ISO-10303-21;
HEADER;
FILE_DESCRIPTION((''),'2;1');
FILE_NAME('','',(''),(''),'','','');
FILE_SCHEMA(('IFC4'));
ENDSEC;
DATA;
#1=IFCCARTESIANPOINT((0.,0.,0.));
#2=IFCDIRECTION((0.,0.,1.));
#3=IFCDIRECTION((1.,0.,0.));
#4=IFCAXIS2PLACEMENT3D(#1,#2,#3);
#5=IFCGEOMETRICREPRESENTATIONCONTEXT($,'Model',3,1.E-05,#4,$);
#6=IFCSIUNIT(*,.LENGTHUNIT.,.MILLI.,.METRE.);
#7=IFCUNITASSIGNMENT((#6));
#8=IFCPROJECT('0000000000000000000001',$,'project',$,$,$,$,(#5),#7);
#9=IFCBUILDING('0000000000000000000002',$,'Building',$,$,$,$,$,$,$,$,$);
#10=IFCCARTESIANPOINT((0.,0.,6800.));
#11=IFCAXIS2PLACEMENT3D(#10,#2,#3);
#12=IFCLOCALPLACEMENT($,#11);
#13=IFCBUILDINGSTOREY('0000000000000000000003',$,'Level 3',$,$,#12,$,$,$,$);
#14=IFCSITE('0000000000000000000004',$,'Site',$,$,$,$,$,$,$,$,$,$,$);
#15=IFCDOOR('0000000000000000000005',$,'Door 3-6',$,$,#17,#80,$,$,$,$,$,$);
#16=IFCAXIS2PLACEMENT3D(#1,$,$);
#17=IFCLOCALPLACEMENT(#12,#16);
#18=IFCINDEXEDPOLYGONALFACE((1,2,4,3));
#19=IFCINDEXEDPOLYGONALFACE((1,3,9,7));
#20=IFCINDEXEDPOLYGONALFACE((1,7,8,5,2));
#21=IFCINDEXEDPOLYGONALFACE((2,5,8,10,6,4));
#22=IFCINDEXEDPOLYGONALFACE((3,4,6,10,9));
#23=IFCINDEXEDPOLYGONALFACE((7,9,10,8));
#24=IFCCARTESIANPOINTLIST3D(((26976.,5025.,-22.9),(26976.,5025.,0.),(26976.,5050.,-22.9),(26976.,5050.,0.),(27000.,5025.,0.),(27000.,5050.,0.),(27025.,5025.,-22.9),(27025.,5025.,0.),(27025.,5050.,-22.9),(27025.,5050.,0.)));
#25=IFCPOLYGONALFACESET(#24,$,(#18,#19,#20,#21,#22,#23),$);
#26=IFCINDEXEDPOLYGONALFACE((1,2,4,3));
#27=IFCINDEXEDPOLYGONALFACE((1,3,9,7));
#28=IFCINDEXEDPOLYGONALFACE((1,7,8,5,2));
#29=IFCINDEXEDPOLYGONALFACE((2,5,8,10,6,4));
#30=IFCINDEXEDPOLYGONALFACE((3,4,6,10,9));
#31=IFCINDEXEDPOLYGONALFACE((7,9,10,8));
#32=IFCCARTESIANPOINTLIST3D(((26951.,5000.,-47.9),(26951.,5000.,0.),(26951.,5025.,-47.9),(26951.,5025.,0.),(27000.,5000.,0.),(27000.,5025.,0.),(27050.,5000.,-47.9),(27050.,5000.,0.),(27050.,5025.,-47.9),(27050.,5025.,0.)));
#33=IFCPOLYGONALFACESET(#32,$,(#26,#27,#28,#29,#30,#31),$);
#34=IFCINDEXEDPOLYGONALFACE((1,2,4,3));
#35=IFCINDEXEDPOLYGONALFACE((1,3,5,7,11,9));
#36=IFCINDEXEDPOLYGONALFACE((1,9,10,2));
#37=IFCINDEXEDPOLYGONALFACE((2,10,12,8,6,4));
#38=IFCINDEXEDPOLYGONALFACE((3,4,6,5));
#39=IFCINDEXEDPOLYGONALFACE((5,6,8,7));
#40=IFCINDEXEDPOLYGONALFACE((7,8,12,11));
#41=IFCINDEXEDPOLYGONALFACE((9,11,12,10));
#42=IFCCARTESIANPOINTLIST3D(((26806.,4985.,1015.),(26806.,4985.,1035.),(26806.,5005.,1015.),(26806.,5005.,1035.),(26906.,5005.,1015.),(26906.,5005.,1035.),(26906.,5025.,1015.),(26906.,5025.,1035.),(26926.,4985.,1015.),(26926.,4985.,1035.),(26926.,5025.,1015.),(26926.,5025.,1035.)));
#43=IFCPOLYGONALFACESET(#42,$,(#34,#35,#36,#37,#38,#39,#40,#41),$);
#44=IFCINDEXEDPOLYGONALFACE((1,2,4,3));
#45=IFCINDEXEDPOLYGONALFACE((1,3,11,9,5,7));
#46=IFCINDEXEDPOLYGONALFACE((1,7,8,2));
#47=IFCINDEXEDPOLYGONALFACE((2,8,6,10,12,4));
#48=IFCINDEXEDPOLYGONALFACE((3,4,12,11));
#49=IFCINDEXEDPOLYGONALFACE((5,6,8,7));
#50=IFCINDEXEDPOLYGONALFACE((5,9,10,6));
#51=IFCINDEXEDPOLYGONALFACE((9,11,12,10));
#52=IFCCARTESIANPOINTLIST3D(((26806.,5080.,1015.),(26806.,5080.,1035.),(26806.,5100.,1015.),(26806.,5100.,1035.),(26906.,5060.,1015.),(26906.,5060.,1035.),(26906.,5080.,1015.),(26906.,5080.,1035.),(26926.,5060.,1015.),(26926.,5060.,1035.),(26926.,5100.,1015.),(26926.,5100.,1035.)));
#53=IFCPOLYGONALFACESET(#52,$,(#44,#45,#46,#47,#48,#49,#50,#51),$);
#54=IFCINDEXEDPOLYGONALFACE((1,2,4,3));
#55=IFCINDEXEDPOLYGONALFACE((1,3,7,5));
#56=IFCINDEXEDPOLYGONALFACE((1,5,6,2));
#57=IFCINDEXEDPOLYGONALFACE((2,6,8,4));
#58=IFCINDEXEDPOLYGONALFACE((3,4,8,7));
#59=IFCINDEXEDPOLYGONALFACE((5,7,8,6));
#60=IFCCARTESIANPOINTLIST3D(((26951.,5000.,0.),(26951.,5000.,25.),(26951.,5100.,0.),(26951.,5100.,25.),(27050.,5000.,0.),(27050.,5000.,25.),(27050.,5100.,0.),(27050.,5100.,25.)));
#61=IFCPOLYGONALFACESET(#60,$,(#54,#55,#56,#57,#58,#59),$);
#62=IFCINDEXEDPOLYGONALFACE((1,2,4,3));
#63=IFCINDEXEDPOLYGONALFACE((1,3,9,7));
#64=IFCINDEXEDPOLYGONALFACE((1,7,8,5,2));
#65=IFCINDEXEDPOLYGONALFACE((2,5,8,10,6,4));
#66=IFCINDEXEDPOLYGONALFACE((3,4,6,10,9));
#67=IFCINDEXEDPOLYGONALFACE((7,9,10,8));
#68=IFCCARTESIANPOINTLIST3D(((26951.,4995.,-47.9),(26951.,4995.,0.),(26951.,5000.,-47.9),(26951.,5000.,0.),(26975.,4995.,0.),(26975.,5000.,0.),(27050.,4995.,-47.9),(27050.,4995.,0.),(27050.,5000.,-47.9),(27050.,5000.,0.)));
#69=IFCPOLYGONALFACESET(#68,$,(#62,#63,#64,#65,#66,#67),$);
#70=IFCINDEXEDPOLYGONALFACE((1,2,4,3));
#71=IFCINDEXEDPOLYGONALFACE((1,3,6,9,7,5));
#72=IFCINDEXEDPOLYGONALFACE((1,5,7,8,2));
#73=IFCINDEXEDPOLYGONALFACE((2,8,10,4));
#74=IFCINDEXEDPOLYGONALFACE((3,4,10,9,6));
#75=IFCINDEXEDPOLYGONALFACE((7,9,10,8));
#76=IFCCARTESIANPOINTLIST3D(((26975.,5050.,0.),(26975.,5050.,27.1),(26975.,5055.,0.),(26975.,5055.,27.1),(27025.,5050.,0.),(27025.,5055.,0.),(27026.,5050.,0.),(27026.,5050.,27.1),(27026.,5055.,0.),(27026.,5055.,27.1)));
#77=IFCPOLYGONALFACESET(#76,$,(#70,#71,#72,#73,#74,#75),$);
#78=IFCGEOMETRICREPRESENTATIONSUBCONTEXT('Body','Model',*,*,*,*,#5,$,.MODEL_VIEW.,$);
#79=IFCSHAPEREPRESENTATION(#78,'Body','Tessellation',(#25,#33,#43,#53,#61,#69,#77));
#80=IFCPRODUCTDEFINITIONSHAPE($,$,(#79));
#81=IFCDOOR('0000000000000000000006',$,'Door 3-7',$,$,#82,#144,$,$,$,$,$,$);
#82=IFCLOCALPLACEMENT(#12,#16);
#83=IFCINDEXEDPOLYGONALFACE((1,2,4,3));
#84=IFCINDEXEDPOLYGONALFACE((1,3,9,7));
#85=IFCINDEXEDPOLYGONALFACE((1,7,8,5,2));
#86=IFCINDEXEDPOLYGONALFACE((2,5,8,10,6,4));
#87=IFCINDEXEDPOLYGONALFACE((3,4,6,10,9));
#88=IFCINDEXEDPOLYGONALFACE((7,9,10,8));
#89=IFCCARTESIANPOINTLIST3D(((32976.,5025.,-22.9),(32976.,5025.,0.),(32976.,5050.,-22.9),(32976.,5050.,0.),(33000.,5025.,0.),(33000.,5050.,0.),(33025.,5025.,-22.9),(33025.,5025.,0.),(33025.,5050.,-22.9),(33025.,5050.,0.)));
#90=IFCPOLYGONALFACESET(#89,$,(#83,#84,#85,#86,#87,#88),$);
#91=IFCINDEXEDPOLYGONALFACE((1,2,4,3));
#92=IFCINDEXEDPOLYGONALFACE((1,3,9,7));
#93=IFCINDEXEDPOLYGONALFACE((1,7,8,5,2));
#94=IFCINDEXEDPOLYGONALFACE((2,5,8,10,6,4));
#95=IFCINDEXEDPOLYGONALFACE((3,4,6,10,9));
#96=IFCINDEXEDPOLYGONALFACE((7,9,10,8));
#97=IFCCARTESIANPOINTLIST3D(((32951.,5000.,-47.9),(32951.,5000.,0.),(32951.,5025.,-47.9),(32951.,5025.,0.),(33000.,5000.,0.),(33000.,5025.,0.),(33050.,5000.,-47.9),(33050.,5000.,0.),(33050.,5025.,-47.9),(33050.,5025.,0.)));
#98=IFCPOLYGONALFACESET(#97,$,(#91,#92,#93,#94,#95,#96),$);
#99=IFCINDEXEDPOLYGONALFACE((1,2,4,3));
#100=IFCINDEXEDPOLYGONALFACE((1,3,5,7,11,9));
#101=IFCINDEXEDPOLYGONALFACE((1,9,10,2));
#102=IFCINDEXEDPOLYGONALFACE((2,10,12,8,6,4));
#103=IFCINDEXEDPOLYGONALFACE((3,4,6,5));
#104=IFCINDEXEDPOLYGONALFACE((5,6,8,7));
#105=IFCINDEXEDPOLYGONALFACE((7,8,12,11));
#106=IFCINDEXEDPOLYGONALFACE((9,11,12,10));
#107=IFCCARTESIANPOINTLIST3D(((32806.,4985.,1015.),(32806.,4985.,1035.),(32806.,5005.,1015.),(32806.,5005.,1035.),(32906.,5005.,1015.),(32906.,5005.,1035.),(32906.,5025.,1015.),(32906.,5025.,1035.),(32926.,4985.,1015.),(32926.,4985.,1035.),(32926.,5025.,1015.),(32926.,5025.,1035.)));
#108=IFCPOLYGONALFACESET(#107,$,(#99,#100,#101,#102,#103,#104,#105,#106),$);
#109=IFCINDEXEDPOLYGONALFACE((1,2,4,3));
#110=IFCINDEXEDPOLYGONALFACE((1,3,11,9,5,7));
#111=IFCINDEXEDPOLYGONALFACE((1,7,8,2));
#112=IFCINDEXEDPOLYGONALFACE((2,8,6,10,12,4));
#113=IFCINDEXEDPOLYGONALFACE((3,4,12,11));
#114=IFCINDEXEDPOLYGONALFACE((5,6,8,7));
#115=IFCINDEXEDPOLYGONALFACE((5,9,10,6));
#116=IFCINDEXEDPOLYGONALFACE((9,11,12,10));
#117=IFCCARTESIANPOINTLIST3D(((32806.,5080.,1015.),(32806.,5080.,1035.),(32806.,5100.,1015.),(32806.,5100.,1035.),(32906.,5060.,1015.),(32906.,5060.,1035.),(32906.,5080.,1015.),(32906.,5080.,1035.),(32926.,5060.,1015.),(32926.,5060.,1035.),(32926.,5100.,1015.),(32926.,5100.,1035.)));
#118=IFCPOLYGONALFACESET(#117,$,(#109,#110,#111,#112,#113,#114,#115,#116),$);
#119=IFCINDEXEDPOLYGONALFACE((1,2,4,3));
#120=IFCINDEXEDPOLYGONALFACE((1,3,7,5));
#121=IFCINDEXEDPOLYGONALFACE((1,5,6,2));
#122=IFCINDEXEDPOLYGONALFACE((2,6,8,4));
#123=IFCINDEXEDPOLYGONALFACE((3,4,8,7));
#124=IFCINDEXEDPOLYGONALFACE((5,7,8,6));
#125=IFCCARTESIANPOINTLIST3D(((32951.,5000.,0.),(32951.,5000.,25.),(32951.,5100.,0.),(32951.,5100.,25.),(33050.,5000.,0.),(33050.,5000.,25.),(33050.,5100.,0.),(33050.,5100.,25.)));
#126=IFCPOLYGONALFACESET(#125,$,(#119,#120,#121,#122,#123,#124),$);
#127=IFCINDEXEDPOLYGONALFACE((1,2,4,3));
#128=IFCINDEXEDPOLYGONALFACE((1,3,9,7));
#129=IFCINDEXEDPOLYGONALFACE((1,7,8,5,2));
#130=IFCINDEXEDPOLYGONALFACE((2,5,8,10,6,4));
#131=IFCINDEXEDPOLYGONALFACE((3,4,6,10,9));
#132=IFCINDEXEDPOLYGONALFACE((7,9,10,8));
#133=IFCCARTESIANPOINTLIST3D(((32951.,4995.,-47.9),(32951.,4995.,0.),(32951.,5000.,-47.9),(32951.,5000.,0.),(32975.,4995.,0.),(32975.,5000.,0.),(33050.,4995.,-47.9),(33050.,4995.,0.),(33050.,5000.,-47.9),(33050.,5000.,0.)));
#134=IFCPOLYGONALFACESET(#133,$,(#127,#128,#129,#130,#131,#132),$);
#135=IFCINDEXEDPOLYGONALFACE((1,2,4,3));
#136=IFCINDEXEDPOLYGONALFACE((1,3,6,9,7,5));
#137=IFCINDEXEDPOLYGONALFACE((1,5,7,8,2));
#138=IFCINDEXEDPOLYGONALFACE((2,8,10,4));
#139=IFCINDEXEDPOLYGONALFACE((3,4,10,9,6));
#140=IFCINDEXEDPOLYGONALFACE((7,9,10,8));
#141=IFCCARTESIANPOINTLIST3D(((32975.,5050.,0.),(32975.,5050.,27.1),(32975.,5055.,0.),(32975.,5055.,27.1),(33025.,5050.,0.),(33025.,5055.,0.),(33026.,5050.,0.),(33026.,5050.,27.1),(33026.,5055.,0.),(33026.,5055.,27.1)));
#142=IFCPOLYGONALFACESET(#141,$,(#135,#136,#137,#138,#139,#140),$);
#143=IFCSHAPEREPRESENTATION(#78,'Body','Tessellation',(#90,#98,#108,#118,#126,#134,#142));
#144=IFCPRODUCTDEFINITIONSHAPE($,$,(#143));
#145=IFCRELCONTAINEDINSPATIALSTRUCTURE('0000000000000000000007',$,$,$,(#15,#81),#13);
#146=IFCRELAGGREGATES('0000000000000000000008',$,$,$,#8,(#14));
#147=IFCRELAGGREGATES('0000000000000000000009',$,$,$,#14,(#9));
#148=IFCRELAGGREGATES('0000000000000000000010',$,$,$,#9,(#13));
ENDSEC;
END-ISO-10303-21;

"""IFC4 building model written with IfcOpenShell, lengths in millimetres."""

from ifc_helpers import new_model, si_unit, frame, origin_with_axes, place, context, subcontext, project, spatial, line, indexed_curve, outline, extrude, element, save


model = new_model("IFC4")

# Units and contexts
model_context = context("Model", 3, precision=1e-05, world=origin_with_axes())
body_context = subcontext(model_context, "Body", "Model", "MODEL_VIEW")
ifc_project = project(units=[si_unit("LENGTHUNIT", "METRE", prefix="MILLI")], contexts=[model_context])

# Site, building, storey
site = spatial("IfcSite", under=ifc_project, Name="Site")
building = spatial("IfcBuilding", under=site, Name="Building")
storey_placement = place(None, frame((0.0, 0.0, 6800.0), z_axis=(0.0, 0.0, 1.0), x_axis=(1.0, 0.0, 0.0)))
storey = spatial("IfcBuildingStorey", under=building, at=storey_placement, Name="Level 3")

# Doors
door_1_placement = place(storey_placement, frame((27000.0, 5000.0, 0.0), z_axis=(0.0, 0.0, 1.0), x_axis=(1.0, 0.0, 0.0)))
element("IfcDoor", 1, at=door_1_placement, inside=storey, Name="Door 3-6", context=body_context, shape_type="SweptSolid", body=[
    extrude(outline(indexed_curve([(0.0, 0.0), (0.0, 2.1), (1.0, 2.1), (1.0, 0.0), (-24.0, 0.0), (-24.0, -22.9), (25.0, -22.9), (25.0, 0.0)], segments=[line(1, 2, 3, 4, 5, 6, 7, 8, 1)])), frame((0.0, 25.0, 0.0), z_axis=(0.0, -1.0, 0.0), x_axis=(1.0, 0.0, 0.0)), (0.0, 0.0, -1.0), 25.0),
    extrude(outline(indexed_curve([(0.0, 0.0), (0.0, 2.1), (1.0, 2.1), (1.0, 0.0), (-49.0, 0.0), (-49.0, -47.9), (50.0, -47.9), (50.0, 0.0)], segments=[line(1, 2, 3, 4, 5, 6, 7, 8, 1)])), frame((0.0, 0.0, 0.0), z_axis=(0.0, -1.0, 0.0), x_axis=(1.0, 0.0, 0.0)), (0.0, 0.0, -1.0), 25.0),
    extrude(outline(indexed_curve([(0.0, 0.0), (-49.0, 0.0), (-49.0, 35.0), (0.0, 35.0)], segments=[line(1, 2, 3, 4, 1)])), frame((25.0, 25.0, 25.0), z_axis=(0.0, 0.0, 1.0), x_axis=(1.0, 0.0, 0.0)), (0.0, 0.0, 1.0), -47.9),
    extrude(outline(indexed_curve([(0.0, 0.0), (0.0, -40.0), (-120.0, -40.0), (-120.0, -20.0), (-20.0, -20.0), (-20.0, 0.0)], segments=[line(1, 2, 3, 4, 5, 6, 1)])), frame((-74.0, 25.0, 1015.0), z_axis=(0.0, 0.0, 1.0), x_axis=(1.0, 0.0, 0.0)), (0.0, 0.0, 1.0), 20.0),
    extrude(outline(indexed_curve([(0.0, 0.0), (0.0, 40.0), (-120.0, 40.0), (-120.0, 20.0), (-20.0, 20.0), (-20.0, 0.0)], segments=[line(1, 2, 3, 4, 5, 6, 1)])), frame((-74.0, 60.0, 1015.0), z_axis=(0.0, 0.0, 1.0), x_axis=(1.0, 0.0, 0.0)), (0.0, 0.0, 1.0), 20.0),
    extrude(outline(indexed_curve([(0.0, 0.0), (-99.0, 0.0), (-99.0, 100.0), (0.0, 100.0)], segments=[line(1, 2, 3, 4, 1)])), frame((50.0, 0.0, 0.0), z_axis=(0.0, 0.0, 1.0), x_axis=(1.0, 0.0, 0.0)), (0.0, 0.0, 1.0), 25.0),
    extrude(outline(indexed_curve([(0.0, 0.0), (0.0, 27.1), (51.0, 27.1), (51.0, 0.0), (-24.0, 0.0), (-24.0, -47.9), (75.0, -47.9), (75.0, 0.0)], segments=[line(1, 2, 3, 4, 5, 6, 7, 8, 1)])), frame((-25.0, -5.0, 0.0), z_axis=(0.0, -1.0, 0.0), x_axis=(1.0, 0.0, 0.0)), (0.0, 0.0, -1.0), 5.0),
    extrude(outline(indexed_curve([(0.0, 0.0), (0.0, 27.1), (51.0, 27.1), (51.0, 0.0), (1.0, 0.0), (1.0, -22.9), (50.0, -22.9), (50.0, 0.0)], segments=[line(1, 2, 3, 4, 5, 6, 7, 8, 1)])), frame((-25.0, 50.0, 0.0), z_axis=(0.0, -1.0, 0.0), x_axis=(1.0, 0.0, 0.0)), (0.0, 0.0, -1.0), 5.0),
])
door_2_placement = place(storey_placement, frame((33000.0, 5000.0, 0.0), z_axis=(0.0, 0.0, 1.0), x_axis=(1.0, 0.0, 0.0)))
element("IfcDoor", 2, at=door_2_placement, inside=storey, Name="Door 3-7", context=body_context, shape_type="SweptSolid", body=[
    extrude(outline(indexed_curve([(0.0, 0.0), (0.0, 2.1), (1.0, 2.1), (1.0, 0.0), (-24.0, 0.0), (-24.0, -22.9), (25.0, -22.9), (25.0, 0.0)], segments=[line(1, 2, 3, 4, 5, 6, 7, 8, 1)])), frame((0.0, 25.0, 0.0), z_axis=(0.0, -1.0, 0.0), x_axis=(1.0, 0.0, 0.0)), (0.0, 0.0, -1.0), 25.0),
    extrude(outline(indexed_curve([(0.0, 0.0), (0.0, 2.1), (1.0, 2.1), (1.0, 0.0), (-49.0, 0.0), (-49.0, -47.9), (50.0, -47.9), (50.0, 0.0)], segments=[line(1, 2, 3, 4, 5, 6, 7, 8, 1)])), frame((0.0, 0.0, 0.0), z_axis=(0.0, -1.0, 0.0), x_axis=(1.0, 0.0, 0.0)), (0.0, 0.0, -1.0), 25.0),
    extrude(outline(indexed_curve([(0.0, 0.0), (-49.0, 0.0), (-49.0, 35.0), (0.0, 35.0)], segments=[line(1, 2, 3, 4, 1)])), frame((25.0, 25.0, 25.0), z_axis=(0.0, 0.0, 1.0), x_axis=(1.0, 0.0, 0.0)), (0.0, 0.0, 1.0), -47.9),
    extrude(outline(indexed_curve([(0.0, 0.0), (0.0, -40.0), (-120.0, -40.0), (-120.0, -20.0), (-20.0, -20.0), (-20.0, 0.0)], segments=[line(1, 2, 3, 4, 5, 6, 1)])), frame((-74.0, 25.0, 1015.0), z_axis=(0.0, 0.0, 1.0), x_axis=(1.0, 0.0, 0.0)), (0.0, 0.0, 1.0), 20.0),
    extrude(outline(indexed_curve([(0.0, 0.0), (0.0, 40.0), (-120.0, 40.0), (-120.0, 20.0), (-20.0, 20.0), (-20.0, 0.0)], segments=[line(1, 2, 3, 4, 5, 6, 1)])), frame((-74.0, 60.0, 1015.0), z_axis=(0.0, 0.0, 1.0), x_axis=(1.0, 0.0, 0.0)), (0.0, 0.0, 1.0), 20.0),
    extrude(outline(indexed_curve([(0.0, 0.0), (-99.0, 0.0), (-99.0, 100.0), (0.0, 100.0)], segments=[line(1, 2, 3, 4, 1)])), frame((50.0, 0.0, 0.0), z_axis=(0.0, 0.0, 1.0), x_axis=(1.0, 0.0, 0.0)), (0.0, 0.0, 1.0), 25.0),
    extrude(outline(indexed_curve([(0.0, 0.0), (0.0, 27.1), (51.0, 27.1), (51.0, 0.0), (-24.0, 0.0), (-24.0, -47.9), (75.0, -47.9), (75.0, 0.0)], segments=[line(1, 2, 3, 4, 5, 6, 7, 8, 1)])), frame((-25.0, -5.0, 0.0), z_axis=(0.0, -1.0, 0.0), x_axis=(1.0, 0.0, 0.0)), (0.0, 0.0, -1.0), 5.0),
    extrude(outline(indexed_curve([(0.0, 0.0), (0.0, 27.1), (51.0, 27.1), (51.0, 0.0), (1.0, 0.0), (1.0, -22.9), (50.0, -22.9), (50.0, 0.0)], segments=[line(1, 2, 3, 4, 5, 6, 7, 8, 1)])), frame((-25.0, 50.0, 0.0), z_axis=(0.0, -1.0, 0.0), x_axis=(1.0, 0.0, 0.0)), (0.0, 0.0, -1.0), 5.0),
])

save(model, "model.ifc")
